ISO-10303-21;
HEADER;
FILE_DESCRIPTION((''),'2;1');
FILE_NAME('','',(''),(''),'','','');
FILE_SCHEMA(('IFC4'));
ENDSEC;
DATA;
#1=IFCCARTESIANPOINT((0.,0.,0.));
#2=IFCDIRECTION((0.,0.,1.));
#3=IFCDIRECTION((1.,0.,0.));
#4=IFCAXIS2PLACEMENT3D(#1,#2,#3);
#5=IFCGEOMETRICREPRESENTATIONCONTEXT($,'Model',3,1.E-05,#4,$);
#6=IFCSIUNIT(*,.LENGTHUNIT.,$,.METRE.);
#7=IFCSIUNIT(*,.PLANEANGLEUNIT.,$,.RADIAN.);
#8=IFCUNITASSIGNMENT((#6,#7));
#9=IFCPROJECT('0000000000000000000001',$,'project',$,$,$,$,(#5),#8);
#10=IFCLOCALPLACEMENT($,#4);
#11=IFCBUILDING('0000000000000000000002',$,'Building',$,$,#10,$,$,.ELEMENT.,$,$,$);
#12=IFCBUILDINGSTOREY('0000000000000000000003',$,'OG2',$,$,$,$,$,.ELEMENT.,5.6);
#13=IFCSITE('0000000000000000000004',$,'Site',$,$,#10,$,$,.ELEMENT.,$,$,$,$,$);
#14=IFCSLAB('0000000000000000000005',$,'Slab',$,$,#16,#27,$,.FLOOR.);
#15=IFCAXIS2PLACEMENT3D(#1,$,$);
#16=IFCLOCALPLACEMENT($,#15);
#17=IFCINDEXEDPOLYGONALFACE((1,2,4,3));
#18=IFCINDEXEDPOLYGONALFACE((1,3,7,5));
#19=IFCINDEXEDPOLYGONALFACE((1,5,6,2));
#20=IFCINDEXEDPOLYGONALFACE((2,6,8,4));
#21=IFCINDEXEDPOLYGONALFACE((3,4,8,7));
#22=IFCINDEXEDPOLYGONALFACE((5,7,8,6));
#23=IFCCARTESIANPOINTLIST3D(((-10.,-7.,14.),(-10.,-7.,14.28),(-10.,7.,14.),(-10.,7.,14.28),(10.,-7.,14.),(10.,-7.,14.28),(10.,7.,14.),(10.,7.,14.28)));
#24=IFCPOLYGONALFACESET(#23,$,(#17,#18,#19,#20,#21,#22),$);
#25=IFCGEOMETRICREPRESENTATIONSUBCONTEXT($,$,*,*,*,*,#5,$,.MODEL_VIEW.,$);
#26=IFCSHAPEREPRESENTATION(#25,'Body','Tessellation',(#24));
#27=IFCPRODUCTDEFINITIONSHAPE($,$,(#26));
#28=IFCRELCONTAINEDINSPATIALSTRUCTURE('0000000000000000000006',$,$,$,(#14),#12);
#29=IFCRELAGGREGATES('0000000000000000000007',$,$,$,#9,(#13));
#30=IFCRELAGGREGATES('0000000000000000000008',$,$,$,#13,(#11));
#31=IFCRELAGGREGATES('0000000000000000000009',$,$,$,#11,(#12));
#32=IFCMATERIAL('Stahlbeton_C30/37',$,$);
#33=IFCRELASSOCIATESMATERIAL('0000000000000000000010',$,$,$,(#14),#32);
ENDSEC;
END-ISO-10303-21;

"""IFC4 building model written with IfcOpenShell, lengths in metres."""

from ifc_helpers import new_model, si_unit, frame, frame_2d, origin, origin_with_axes, place, context, subcontext, project, spatial, rectangle, extrude, material, element, save


model = new_model("IFC4")

# Units and contexts
model_context = context("Model", 3, precision=1e-05, world=origin_with_axes())
sub_context = subcontext(model_context, None, None, "MODEL_VIEW")
ifc_project = project(units=[si_unit("LENGTHUNIT", "METRE"), si_unit("PLANEANGLEUNIT", "RADIAN")], contexts=[model_context])

# Site, building, storey
placement_1 = place(None, origin_with_axes())
site = spatial("IfcSite", under=ifc_project, at=placement_1, Name="Site", CompositionType="ELEMENT")
building = spatial("IfcBuilding", under=site, at=placement_1, Name="Building", CompositionType="ELEMENT")
storey = spatial("IfcBuildingStorey", under=building, Name="OG2", CompositionType="ELEMENT", Elevation=5.6)

# Slab
ifc_material = material(Name="Stahlbeton_C30/37")
placement_2 = place(None, origin_with_axes())
placement_3 = place(placement_2, frame((0.0, 0.0, 5.6)))
slab_placement = place(placement_3, frame((-10.0, -7.0, 8.4)))
element("IfcSlab", 1, at=slab_placement, inside=storey, material=ifc_material, Name="Slab", PredefinedType="FLOOR", context=sub_context, shape_type="SweptSolid", body=[
    extrude(rectangle(XDim=20.0, YDim=14.0, at=frame_2d((10.0, 7.0))), origin(), (0.0, 0.0, 1.0), 0.28),
])

save(model, "model.ifc")
